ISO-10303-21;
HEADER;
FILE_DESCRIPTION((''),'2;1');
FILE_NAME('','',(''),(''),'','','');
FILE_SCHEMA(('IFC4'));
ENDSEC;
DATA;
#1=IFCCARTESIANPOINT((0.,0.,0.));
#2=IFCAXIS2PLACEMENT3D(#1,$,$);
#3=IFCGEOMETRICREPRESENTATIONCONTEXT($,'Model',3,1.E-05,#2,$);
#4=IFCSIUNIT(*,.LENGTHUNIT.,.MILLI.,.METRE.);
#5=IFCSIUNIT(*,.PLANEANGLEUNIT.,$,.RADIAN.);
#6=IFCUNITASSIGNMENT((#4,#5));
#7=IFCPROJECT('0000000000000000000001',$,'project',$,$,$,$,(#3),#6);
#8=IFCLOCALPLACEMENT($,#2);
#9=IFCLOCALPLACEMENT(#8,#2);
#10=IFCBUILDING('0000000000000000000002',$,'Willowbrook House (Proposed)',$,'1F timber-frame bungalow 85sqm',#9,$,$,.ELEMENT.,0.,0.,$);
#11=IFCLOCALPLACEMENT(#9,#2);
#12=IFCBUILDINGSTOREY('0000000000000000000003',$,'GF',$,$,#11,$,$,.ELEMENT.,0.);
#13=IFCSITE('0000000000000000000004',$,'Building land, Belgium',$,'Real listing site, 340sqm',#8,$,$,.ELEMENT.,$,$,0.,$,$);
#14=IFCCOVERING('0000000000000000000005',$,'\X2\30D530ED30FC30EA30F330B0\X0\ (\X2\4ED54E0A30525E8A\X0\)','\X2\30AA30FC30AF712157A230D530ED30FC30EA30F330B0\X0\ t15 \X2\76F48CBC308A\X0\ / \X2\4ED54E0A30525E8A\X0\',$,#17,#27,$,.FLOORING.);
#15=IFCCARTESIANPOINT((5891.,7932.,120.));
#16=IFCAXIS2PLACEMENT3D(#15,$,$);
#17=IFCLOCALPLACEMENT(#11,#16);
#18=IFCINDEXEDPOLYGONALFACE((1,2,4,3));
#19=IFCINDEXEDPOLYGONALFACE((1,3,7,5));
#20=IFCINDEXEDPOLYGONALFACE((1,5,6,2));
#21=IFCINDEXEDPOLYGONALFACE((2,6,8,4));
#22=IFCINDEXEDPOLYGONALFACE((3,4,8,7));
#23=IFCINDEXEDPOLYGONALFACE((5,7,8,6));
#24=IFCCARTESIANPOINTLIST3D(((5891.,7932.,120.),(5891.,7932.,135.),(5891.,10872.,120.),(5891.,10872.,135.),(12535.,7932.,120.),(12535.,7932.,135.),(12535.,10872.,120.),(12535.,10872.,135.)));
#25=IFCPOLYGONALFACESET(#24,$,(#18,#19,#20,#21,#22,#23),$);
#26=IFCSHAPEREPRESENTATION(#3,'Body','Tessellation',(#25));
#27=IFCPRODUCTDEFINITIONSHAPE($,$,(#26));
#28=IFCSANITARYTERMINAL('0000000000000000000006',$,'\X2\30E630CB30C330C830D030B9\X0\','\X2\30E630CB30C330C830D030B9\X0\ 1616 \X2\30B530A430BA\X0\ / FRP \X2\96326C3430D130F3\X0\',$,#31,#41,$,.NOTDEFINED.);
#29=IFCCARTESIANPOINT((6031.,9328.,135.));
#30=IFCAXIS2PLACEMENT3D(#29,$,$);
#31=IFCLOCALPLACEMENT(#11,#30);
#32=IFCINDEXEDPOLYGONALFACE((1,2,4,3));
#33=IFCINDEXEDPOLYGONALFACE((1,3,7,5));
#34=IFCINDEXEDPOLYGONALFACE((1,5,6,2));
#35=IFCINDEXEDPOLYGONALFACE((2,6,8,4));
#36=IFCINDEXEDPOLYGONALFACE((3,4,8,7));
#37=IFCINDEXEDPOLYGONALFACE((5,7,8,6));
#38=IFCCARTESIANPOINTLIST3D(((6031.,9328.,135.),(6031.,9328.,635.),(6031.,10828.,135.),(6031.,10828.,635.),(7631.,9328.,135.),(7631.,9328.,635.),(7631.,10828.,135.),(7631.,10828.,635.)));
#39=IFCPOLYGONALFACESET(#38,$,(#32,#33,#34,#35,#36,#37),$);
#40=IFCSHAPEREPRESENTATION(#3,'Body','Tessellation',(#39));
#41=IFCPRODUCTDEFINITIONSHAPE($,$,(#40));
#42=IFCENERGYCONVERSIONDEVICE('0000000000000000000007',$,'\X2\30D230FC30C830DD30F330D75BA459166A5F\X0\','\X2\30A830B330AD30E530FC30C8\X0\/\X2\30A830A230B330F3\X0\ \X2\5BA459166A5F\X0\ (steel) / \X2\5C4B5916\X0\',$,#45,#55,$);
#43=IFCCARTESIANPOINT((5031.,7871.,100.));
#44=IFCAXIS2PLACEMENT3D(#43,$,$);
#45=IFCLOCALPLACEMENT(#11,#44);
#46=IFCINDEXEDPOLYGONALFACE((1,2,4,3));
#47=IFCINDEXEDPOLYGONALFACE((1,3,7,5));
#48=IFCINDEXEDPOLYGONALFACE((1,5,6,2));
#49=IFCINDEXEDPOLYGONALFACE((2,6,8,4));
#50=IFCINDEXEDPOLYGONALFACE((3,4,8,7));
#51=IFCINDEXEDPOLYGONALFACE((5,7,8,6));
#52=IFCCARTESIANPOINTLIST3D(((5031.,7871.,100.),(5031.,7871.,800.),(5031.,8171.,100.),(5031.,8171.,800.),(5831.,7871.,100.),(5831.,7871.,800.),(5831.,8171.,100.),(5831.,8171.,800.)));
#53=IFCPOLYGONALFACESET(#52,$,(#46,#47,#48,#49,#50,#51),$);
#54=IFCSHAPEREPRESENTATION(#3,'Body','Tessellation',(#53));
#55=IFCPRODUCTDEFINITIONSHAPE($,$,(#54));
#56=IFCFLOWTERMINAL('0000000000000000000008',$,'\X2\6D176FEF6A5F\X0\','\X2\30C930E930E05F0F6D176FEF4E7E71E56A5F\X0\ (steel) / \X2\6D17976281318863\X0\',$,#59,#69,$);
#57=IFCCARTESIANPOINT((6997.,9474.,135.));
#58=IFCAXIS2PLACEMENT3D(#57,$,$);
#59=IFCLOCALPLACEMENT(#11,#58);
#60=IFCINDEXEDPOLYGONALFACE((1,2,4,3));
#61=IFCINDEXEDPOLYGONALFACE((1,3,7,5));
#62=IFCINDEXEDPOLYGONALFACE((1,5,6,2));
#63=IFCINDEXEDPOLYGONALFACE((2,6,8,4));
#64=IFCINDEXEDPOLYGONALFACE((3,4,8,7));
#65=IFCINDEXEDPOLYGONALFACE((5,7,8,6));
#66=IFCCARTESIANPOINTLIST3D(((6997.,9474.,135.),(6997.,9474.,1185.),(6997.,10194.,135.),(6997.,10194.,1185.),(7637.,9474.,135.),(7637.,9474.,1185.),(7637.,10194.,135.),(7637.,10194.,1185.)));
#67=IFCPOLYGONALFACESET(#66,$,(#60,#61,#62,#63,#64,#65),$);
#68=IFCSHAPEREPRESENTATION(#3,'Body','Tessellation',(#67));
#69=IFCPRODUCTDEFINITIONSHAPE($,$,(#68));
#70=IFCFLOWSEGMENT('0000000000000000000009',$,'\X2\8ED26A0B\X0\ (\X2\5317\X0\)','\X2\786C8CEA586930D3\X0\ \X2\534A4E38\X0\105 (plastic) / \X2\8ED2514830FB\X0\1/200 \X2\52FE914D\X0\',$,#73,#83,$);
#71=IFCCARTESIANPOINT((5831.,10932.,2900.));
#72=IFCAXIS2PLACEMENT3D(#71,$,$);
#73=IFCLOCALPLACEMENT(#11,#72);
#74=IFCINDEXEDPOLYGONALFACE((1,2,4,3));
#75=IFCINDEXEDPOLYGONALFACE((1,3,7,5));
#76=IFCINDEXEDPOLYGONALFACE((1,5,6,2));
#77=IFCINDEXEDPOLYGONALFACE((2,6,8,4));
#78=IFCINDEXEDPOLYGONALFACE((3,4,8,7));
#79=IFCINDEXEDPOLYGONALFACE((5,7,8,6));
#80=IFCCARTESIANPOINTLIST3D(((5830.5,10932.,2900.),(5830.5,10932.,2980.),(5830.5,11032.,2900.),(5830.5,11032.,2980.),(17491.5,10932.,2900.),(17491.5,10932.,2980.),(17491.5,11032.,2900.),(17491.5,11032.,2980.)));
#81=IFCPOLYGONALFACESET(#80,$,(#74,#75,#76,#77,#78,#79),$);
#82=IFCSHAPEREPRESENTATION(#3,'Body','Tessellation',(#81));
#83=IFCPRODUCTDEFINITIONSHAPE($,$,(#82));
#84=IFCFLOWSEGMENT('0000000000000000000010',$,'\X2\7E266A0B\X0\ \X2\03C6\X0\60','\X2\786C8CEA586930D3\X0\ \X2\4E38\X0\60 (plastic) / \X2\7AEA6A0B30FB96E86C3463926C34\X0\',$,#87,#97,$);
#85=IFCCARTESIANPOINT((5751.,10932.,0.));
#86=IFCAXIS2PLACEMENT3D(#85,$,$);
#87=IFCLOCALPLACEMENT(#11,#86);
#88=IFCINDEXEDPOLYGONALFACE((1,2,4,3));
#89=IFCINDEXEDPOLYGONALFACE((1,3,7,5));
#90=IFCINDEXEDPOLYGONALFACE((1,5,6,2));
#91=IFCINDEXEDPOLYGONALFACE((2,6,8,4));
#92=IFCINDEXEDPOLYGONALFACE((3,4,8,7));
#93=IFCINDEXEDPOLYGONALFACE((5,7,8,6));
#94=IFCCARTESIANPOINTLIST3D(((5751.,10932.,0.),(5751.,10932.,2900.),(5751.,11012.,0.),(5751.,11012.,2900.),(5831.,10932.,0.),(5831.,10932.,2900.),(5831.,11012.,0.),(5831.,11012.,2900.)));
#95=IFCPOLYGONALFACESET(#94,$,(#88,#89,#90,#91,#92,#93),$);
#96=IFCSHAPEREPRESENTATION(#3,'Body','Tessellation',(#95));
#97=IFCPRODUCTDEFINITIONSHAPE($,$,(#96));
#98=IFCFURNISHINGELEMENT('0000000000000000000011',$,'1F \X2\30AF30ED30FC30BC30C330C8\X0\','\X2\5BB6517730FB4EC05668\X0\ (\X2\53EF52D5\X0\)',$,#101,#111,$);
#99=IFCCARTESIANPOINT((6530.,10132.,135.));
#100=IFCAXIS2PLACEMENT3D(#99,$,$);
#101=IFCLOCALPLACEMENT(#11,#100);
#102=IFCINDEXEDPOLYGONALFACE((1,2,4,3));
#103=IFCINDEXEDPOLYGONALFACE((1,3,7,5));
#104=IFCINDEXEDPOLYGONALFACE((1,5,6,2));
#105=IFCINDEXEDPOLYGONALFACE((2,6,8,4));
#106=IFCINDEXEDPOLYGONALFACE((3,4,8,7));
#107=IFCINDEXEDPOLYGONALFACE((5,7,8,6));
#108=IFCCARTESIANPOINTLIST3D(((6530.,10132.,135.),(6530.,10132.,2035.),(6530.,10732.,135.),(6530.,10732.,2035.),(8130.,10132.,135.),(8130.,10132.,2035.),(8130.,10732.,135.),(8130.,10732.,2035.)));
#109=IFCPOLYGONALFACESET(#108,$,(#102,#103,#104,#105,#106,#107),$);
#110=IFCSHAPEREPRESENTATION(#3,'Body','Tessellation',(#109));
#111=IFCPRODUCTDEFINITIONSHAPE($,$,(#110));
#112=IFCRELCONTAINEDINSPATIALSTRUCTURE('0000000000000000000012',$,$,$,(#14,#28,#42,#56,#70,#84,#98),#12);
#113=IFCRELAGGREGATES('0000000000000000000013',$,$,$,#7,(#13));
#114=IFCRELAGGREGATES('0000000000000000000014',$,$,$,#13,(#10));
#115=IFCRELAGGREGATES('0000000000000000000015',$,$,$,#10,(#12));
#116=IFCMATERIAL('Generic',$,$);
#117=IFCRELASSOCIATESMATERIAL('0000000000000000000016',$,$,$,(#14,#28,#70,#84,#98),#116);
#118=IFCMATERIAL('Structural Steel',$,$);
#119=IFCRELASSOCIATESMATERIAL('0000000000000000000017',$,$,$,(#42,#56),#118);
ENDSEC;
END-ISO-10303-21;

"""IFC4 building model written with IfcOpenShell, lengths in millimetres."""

from ifc_helpers import new_model, si_unit, frame, frame_2d, origin, place, context, project, spatial, rectangle, extrude, material, element, save


model = new_model("IFC4")

# Units and contexts
model_context = context("Model", 3, precision=1e-05, world=origin())
ifc_project = project(units=[si_unit("LENGTHUNIT", "METRE", prefix="MILLI"), si_unit("PLANEANGLEUNIT", "RADIAN")], contexts=[model_context])

# Site, building, storey
site_placement = place(None, origin())
site = spatial("IfcSite", under=ifc_project, at=site_placement, Name="Building land, Belgium", ObjectType="Real listing site, 340sqm", CompositionType="ELEMENT", RefElevation=0.0)
building_placement = place(site_placement, origin())
building = spatial("IfcBuilding", under=site, at=building_placement, Name="Willowbrook House (Proposed)", ObjectType="1F timber-frame bungalow 85sqm", CompositionType="ELEMENT", ElevationOfRefHeight=0.0, ElevationOfTerrain=0.0)
storey_placement = place(building_placement, origin())
storey = spatial("IfcBuildingStorey", under=building, at=storey_placement, Name="GF", CompositionType="ELEMENT", Elevation=0.0)

# Shared definitions
ifc_material_1 = material(Name="Structural Steel")

# Covering
ifc_material_2 = material(Name="Generic")
covering_placement = place(storey_placement, frame((5891.0, 7932.0, 120.0)))
element("IfcCovering", 1, at=covering_placement, inside=storey, material=ifc_material_2, Name="フローリング (仕上げ床)", Description="オーク無垢フローリング t15 直貼り / 仕上げ床", PredefinedType="FLOORING", context=model_context, shape_type="SweptSolid", body=[
    extrude(rectangle(XDim=6644.0, YDim=2940.0, at=frame_2d((3322.0, 1470.0))), frame((5891.0, 7932.0, 120.0)), (0.0, 0.0, 1.0), 15.0),
])

# Sanitary terminal
sanitary_terminal_placement = place(storey_placement, frame((6031.0, 9328.0, 135.0)))
element("IfcSanitaryTerminal", 2, at=sanitary_terminal_placement, inside=storey, material=ifc_material_2, Name="ユニットバス", Description="ユニットバス 1616 サイズ / FRP 防水パン", PredefinedType="NOTDEFINED", context=model_context, shape_type="SweptSolid", body=[
    extrude(rectangle(XDim=1600.0, YDim=1500.0, at=frame_2d((800.0, 750.0))), frame((6031.0, 9328.0, 135.0)), (0.0, 0.0, 1.0), 500.0),
])

# Energy conversion device
energy_conversion_device_placement = place(storey_placement, frame((5031.0, 7871.0, 100.0)))
element("IfcEnergyConversionDevice", 3, at=energy_conversion_device_placement, inside=storey, material=ifc_material_1, Name="ヒートポンプ室外機", Description="エコキュート/エアコン 室外機 (steel) / 屋外", context=model_context, shape_type="SweptSolid", body=[
    extrude(rectangle(XDim=800.0, YDim=300.0, at=frame_2d((400.0, 150.0))), frame((5031.0, 7871.0, 100.0)), (0.0, 0.0, 1.0), 700.0),
])

# Flow terminal
flow_terminal_placement = place(storey_placement, frame((6997.0, 9474.0, 135.0)))
element("IfcFlowTerminal", 4, at=flow_terminal_placement, inside=storey, material=ifc_material_1, Name="洗濯機", Description="ドラム式洗濯乾燥機 (steel) / 洗面脱衣", context=model_context, shape_type="SweptSolid", body=[
    extrude(rectangle(XDim=640.0, YDim=720.0, at=frame_2d((320.0, 360.0))), frame((6997.0, 9474.0, 135.0)), (0.0, 0.0, 1.0), 1050.0),
])

# Flow segments
flow_segment_1_placement = place(storey_placement, frame((5831.0, 10932.0, 2900.0)))
element("IfcFlowSegment", 5, at=flow_segment_1_placement, inside=storey, material=ifc_material_2, Name="軒樋 (北)", Description="硬質塩ビ 半丸105 (plastic) / 軒先・1/200 勾配", context=model_context, shape_type="SweptSolid", body=[
    extrude(rectangle(XDim=11661.0, YDim=100.0, at=frame_2d((5830.0, 50.0))), frame((5831.0, 10932.0, 2900.0)), (0.0, 0.0, 1.0), 80.0),
])
flow_segment_2_placement = place(storey_placement, frame((5751.0, 10932.0, 0.0)))
element("IfcFlowSegment", 6, at=flow_segment_2_placement, inside=storey, material=ifc_material_2, Name="縦樋 φ60", Description="硬質塩ビ 丸60 (plastic) / 竪樋・雨水排水", context=model_context, shape_type="SweptSolid", body=[
    extrude(rectangle(XDim=80.0, YDim=80.0, at=frame_2d((40.0, 40.0))), frame((5751.0, 10932.0, 0.0)), (0.0, 0.0, 1.0), 2900.0),
])

# Furnishing element
furnishing_placement = place(storey_placement, frame((6530.0, 10132.0, 135.0)))
element("IfcFurnishingElement", 7, at=furnishing_placement, inside=storey, material=ifc_material_2, Name="1F クローゼット", Description="家具・什器 (可動)", context=model_context, shape_type="SweptSolid", body=[
    extrude(rectangle(XDim=1600.0, YDim=600.0, at=frame_2d((800.0, 300.0))), frame((6530.0, 10132.0, 135.0)), (0.0, 0.0, 1.0), 1900.0),
])

save(model, "model.ifc")
